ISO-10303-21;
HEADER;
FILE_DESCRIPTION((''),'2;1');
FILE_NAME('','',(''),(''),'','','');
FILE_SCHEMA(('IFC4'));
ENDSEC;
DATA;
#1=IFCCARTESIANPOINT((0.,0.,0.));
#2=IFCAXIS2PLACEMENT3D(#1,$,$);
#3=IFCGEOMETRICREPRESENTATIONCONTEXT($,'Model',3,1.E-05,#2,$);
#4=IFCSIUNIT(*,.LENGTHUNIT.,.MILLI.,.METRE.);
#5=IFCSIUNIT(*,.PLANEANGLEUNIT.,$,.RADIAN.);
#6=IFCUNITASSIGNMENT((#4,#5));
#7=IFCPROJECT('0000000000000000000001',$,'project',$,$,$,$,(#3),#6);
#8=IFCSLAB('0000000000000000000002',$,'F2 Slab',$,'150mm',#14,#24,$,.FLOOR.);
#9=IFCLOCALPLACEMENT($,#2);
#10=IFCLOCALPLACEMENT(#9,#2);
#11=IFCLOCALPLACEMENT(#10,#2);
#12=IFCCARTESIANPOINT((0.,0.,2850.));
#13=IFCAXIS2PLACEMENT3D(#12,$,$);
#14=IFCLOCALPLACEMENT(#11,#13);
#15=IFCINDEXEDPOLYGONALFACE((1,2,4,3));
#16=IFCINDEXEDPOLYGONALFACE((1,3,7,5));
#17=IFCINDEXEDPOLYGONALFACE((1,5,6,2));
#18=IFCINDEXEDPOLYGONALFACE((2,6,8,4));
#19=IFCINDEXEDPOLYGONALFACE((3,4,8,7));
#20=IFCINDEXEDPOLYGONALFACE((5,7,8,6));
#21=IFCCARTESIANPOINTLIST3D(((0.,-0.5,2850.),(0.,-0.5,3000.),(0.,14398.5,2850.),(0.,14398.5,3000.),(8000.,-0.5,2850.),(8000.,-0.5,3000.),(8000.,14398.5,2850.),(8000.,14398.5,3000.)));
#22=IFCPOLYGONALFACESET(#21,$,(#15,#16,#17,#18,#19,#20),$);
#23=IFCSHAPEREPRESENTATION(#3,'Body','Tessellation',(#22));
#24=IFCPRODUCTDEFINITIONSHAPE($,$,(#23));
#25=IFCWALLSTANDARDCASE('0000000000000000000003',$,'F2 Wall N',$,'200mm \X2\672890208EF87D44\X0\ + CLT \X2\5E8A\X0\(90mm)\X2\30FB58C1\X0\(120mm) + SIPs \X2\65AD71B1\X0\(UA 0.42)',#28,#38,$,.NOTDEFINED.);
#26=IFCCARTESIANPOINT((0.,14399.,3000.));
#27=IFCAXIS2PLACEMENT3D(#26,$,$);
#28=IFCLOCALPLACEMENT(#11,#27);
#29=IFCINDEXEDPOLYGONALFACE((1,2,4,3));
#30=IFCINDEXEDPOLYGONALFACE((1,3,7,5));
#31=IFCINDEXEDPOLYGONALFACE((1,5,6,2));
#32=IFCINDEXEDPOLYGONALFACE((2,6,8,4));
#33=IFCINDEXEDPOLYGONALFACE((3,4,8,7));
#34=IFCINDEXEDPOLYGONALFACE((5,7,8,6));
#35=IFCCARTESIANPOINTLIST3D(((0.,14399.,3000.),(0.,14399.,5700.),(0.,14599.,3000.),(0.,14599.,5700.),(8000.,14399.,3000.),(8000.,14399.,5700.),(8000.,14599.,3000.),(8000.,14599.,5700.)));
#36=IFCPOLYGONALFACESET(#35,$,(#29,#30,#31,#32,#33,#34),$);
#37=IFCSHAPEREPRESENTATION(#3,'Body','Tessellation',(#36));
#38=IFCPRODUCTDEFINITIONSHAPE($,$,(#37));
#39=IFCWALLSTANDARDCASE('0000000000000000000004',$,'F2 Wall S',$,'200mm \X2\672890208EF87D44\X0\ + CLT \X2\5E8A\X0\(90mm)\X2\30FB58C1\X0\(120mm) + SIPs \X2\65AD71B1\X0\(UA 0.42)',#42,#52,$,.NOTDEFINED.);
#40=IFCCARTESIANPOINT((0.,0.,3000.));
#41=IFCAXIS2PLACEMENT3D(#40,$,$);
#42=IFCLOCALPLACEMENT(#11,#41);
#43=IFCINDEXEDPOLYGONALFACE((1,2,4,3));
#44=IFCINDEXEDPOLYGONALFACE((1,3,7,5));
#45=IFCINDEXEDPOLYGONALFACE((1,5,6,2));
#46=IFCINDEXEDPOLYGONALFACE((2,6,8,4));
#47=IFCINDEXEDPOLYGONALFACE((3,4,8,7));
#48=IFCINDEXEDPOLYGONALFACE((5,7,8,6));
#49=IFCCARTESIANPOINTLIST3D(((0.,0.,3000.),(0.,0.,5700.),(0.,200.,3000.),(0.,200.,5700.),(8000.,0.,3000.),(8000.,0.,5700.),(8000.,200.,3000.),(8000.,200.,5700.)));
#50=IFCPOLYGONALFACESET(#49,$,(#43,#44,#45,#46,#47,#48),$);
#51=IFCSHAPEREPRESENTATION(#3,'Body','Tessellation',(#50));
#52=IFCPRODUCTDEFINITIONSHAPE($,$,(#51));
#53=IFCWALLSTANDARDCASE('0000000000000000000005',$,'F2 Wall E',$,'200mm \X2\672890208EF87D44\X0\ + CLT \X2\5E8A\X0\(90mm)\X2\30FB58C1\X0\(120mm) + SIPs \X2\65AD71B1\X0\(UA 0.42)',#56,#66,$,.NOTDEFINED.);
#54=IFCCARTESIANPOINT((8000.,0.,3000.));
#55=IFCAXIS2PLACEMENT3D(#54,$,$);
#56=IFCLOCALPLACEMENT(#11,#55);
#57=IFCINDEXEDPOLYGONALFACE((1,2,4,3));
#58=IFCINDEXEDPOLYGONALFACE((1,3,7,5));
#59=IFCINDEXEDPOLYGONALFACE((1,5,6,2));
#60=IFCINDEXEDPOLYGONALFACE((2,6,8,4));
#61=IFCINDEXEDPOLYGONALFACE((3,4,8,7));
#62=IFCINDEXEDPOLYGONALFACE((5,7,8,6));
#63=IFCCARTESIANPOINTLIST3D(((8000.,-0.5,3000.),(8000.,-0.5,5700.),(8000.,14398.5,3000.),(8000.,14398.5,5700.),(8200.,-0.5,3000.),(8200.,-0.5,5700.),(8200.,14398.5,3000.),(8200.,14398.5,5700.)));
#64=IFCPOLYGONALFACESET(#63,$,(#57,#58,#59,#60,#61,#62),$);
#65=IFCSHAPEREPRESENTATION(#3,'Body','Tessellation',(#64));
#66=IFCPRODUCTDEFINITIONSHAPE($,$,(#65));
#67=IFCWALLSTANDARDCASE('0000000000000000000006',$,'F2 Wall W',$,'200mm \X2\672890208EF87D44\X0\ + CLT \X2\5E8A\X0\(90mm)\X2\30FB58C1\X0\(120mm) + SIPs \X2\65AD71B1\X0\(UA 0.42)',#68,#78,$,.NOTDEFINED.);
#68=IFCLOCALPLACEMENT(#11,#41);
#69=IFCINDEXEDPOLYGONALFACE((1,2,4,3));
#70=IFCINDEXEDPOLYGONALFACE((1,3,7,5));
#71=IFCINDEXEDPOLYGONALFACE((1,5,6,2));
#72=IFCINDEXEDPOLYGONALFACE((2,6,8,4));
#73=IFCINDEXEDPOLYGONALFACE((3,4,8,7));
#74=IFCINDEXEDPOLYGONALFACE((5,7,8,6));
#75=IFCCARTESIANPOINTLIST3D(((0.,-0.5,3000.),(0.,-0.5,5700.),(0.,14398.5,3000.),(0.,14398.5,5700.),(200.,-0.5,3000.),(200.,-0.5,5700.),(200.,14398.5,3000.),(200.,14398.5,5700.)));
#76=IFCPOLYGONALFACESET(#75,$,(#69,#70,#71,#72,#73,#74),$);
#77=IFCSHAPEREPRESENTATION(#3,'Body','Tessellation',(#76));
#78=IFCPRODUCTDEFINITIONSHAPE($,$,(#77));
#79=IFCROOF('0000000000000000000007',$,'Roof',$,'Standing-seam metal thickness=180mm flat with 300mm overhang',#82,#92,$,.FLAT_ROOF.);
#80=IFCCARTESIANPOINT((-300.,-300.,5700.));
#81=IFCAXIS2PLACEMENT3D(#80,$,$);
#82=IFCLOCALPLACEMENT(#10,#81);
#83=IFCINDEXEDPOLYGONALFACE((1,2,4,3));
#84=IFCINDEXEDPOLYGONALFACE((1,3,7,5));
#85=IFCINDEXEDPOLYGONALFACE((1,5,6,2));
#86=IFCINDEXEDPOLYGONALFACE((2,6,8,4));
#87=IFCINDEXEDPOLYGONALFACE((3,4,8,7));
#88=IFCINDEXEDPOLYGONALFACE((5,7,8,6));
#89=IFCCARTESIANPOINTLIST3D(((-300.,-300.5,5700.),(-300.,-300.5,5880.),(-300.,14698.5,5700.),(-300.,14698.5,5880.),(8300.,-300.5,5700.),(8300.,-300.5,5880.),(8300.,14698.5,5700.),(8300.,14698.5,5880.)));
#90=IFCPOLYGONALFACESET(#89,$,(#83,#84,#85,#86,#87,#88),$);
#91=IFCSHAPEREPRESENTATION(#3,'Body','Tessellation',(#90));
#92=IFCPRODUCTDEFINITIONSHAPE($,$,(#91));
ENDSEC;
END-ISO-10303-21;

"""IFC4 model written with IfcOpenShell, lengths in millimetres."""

from ifc_helpers import new_model, si_unit, frame, frame_2d, origin, place, context, project, rectangle, extrude, element, save


model = new_model("IFC4")

# Units and contexts
model_context = context("Model", 3, precision=1e-05, world=origin())
ifc_project = project(units=[si_unit("LENGTHUNIT", "METRE", prefix="MILLI"), si_unit("PLANEANGLEUNIT", "RADIAN")], contexts=[model_context])

# Slab
placement_1 = place(None, origin())
placement_2 = place(placement_1, origin())
placement_3 = place(placement_2, origin())
slab_placement = place(placement_3, frame((0.0, 0.0, 2850.0)))
element("IfcSlab", 1, at=slab_placement, Name="F2 Slab", ObjectType="150mm", PredefinedType="FLOOR", context=model_context, shape_type="SweptSolid", body=[
    extrude(rectangle(XDim=8000.0, YDim=14399.0, at=frame_2d((4000.0, 7199.0))), frame((0.0, 0.0, 2850.0)), (0.0, 0.0, 1.0), 150.0),
])

# Walls
wall_1_placement = place(placement_3, frame((0.0, 14399.0, 3000.0)))
element("IfcWallStandardCase", 2, at=wall_1_placement, Name="F2 Wall N", ObjectType="200mm 木造軸組 + CLT 床(90mm)・壁(120mm) + SIPs 断熱(UA 0.42)", PredefinedType="NOTDEFINED", context=model_context, shape_type="SweptSolid", body=[
    extrude(rectangle(XDim=8000.0, YDim=200.0, at=frame_2d((4000.0, 100.0))), frame((0.0, 14399.0, 3000.0)), (0.0, 0.0, 1.0), 2700.0),
])
wall_2_placement = place(placement_3, frame((0.0, 0.0, 3000.0)))
element("IfcWallStandardCase", 3, at=wall_2_placement, Name="F2 Wall S", ObjectType="200mm 木造軸組 + CLT 床(90mm)・壁(120mm) + SIPs 断熱(UA 0.42)", PredefinedType="NOTDEFINED", context=model_context, shape_type="SweptSolid", body=[
    extrude(rectangle(XDim=8000.0, YDim=200.0, at=frame_2d((4000.0, 100.0))), frame((0.0, 0.0, 3000.0)), (0.0, 0.0, 1.0), 2700.0),
])
wall_3_placement = place(placement_3, frame((8000.0, 0.0, 3000.0)))
element("IfcWallStandardCase", 4, at=wall_3_placement, Name="F2 Wall E", ObjectType="200mm 木造軸組 + CLT 床(90mm)・壁(120mm) + SIPs 断熱(UA 0.42)", PredefinedType="NOTDEFINED", context=model_context, shape_type="SweptSolid", body=[
    extrude(rectangle(XDim=200.0, YDim=14399.0, at=frame_2d((100.0, 7199.0))), frame((8000.0, 0.0, 3000.0)), (0.0, 0.0, 1.0), 2700.0),
])
wall_4_placement = place(placement_3, frame((0.0, 0.0, 3000.0)))
element("IfcWallStandardCase", 5, at=wall_4_placement, Name="F2 Wall W", ObjectType="200mm 木造軸組 + CLT 床(90mm)・壁(120mm) + SIPs 断熱(UA 0.42)", PredefinedType="NOTDEFINED", context=model_context, shape_type="SweptSolid", body=[
    extrude(rectangle(XDim=200.0, YDim=14399.0, at=frame_2d((100.0, 7199.0))), frame((0.0, 0.0, 3000.0)), (0.0, 0.0, 1.0), 2700.0),
])

# Roof
roof_placement = place(placement_2, frame((-300.0, -300.0, 5700.0)))
element("IfcRoof", 6, at=roof_placement, Name="Roof", ObjectType="Standing-seam metal thickness=180mm flat with 300mm overhang", PredefinedType="FLAT_ROOF", context=model_context, shape_type="SweptSolid", body=[
    extrude(rectangle(XDim=8600.0, YDim=14999.0, at=frame_2d((4300.0, 7499.0))), frame((-300.0, -300.0, 5700.0)), (0.0, 0.0, 1.0), 180.0),
])

save(model, "model.ifc")
